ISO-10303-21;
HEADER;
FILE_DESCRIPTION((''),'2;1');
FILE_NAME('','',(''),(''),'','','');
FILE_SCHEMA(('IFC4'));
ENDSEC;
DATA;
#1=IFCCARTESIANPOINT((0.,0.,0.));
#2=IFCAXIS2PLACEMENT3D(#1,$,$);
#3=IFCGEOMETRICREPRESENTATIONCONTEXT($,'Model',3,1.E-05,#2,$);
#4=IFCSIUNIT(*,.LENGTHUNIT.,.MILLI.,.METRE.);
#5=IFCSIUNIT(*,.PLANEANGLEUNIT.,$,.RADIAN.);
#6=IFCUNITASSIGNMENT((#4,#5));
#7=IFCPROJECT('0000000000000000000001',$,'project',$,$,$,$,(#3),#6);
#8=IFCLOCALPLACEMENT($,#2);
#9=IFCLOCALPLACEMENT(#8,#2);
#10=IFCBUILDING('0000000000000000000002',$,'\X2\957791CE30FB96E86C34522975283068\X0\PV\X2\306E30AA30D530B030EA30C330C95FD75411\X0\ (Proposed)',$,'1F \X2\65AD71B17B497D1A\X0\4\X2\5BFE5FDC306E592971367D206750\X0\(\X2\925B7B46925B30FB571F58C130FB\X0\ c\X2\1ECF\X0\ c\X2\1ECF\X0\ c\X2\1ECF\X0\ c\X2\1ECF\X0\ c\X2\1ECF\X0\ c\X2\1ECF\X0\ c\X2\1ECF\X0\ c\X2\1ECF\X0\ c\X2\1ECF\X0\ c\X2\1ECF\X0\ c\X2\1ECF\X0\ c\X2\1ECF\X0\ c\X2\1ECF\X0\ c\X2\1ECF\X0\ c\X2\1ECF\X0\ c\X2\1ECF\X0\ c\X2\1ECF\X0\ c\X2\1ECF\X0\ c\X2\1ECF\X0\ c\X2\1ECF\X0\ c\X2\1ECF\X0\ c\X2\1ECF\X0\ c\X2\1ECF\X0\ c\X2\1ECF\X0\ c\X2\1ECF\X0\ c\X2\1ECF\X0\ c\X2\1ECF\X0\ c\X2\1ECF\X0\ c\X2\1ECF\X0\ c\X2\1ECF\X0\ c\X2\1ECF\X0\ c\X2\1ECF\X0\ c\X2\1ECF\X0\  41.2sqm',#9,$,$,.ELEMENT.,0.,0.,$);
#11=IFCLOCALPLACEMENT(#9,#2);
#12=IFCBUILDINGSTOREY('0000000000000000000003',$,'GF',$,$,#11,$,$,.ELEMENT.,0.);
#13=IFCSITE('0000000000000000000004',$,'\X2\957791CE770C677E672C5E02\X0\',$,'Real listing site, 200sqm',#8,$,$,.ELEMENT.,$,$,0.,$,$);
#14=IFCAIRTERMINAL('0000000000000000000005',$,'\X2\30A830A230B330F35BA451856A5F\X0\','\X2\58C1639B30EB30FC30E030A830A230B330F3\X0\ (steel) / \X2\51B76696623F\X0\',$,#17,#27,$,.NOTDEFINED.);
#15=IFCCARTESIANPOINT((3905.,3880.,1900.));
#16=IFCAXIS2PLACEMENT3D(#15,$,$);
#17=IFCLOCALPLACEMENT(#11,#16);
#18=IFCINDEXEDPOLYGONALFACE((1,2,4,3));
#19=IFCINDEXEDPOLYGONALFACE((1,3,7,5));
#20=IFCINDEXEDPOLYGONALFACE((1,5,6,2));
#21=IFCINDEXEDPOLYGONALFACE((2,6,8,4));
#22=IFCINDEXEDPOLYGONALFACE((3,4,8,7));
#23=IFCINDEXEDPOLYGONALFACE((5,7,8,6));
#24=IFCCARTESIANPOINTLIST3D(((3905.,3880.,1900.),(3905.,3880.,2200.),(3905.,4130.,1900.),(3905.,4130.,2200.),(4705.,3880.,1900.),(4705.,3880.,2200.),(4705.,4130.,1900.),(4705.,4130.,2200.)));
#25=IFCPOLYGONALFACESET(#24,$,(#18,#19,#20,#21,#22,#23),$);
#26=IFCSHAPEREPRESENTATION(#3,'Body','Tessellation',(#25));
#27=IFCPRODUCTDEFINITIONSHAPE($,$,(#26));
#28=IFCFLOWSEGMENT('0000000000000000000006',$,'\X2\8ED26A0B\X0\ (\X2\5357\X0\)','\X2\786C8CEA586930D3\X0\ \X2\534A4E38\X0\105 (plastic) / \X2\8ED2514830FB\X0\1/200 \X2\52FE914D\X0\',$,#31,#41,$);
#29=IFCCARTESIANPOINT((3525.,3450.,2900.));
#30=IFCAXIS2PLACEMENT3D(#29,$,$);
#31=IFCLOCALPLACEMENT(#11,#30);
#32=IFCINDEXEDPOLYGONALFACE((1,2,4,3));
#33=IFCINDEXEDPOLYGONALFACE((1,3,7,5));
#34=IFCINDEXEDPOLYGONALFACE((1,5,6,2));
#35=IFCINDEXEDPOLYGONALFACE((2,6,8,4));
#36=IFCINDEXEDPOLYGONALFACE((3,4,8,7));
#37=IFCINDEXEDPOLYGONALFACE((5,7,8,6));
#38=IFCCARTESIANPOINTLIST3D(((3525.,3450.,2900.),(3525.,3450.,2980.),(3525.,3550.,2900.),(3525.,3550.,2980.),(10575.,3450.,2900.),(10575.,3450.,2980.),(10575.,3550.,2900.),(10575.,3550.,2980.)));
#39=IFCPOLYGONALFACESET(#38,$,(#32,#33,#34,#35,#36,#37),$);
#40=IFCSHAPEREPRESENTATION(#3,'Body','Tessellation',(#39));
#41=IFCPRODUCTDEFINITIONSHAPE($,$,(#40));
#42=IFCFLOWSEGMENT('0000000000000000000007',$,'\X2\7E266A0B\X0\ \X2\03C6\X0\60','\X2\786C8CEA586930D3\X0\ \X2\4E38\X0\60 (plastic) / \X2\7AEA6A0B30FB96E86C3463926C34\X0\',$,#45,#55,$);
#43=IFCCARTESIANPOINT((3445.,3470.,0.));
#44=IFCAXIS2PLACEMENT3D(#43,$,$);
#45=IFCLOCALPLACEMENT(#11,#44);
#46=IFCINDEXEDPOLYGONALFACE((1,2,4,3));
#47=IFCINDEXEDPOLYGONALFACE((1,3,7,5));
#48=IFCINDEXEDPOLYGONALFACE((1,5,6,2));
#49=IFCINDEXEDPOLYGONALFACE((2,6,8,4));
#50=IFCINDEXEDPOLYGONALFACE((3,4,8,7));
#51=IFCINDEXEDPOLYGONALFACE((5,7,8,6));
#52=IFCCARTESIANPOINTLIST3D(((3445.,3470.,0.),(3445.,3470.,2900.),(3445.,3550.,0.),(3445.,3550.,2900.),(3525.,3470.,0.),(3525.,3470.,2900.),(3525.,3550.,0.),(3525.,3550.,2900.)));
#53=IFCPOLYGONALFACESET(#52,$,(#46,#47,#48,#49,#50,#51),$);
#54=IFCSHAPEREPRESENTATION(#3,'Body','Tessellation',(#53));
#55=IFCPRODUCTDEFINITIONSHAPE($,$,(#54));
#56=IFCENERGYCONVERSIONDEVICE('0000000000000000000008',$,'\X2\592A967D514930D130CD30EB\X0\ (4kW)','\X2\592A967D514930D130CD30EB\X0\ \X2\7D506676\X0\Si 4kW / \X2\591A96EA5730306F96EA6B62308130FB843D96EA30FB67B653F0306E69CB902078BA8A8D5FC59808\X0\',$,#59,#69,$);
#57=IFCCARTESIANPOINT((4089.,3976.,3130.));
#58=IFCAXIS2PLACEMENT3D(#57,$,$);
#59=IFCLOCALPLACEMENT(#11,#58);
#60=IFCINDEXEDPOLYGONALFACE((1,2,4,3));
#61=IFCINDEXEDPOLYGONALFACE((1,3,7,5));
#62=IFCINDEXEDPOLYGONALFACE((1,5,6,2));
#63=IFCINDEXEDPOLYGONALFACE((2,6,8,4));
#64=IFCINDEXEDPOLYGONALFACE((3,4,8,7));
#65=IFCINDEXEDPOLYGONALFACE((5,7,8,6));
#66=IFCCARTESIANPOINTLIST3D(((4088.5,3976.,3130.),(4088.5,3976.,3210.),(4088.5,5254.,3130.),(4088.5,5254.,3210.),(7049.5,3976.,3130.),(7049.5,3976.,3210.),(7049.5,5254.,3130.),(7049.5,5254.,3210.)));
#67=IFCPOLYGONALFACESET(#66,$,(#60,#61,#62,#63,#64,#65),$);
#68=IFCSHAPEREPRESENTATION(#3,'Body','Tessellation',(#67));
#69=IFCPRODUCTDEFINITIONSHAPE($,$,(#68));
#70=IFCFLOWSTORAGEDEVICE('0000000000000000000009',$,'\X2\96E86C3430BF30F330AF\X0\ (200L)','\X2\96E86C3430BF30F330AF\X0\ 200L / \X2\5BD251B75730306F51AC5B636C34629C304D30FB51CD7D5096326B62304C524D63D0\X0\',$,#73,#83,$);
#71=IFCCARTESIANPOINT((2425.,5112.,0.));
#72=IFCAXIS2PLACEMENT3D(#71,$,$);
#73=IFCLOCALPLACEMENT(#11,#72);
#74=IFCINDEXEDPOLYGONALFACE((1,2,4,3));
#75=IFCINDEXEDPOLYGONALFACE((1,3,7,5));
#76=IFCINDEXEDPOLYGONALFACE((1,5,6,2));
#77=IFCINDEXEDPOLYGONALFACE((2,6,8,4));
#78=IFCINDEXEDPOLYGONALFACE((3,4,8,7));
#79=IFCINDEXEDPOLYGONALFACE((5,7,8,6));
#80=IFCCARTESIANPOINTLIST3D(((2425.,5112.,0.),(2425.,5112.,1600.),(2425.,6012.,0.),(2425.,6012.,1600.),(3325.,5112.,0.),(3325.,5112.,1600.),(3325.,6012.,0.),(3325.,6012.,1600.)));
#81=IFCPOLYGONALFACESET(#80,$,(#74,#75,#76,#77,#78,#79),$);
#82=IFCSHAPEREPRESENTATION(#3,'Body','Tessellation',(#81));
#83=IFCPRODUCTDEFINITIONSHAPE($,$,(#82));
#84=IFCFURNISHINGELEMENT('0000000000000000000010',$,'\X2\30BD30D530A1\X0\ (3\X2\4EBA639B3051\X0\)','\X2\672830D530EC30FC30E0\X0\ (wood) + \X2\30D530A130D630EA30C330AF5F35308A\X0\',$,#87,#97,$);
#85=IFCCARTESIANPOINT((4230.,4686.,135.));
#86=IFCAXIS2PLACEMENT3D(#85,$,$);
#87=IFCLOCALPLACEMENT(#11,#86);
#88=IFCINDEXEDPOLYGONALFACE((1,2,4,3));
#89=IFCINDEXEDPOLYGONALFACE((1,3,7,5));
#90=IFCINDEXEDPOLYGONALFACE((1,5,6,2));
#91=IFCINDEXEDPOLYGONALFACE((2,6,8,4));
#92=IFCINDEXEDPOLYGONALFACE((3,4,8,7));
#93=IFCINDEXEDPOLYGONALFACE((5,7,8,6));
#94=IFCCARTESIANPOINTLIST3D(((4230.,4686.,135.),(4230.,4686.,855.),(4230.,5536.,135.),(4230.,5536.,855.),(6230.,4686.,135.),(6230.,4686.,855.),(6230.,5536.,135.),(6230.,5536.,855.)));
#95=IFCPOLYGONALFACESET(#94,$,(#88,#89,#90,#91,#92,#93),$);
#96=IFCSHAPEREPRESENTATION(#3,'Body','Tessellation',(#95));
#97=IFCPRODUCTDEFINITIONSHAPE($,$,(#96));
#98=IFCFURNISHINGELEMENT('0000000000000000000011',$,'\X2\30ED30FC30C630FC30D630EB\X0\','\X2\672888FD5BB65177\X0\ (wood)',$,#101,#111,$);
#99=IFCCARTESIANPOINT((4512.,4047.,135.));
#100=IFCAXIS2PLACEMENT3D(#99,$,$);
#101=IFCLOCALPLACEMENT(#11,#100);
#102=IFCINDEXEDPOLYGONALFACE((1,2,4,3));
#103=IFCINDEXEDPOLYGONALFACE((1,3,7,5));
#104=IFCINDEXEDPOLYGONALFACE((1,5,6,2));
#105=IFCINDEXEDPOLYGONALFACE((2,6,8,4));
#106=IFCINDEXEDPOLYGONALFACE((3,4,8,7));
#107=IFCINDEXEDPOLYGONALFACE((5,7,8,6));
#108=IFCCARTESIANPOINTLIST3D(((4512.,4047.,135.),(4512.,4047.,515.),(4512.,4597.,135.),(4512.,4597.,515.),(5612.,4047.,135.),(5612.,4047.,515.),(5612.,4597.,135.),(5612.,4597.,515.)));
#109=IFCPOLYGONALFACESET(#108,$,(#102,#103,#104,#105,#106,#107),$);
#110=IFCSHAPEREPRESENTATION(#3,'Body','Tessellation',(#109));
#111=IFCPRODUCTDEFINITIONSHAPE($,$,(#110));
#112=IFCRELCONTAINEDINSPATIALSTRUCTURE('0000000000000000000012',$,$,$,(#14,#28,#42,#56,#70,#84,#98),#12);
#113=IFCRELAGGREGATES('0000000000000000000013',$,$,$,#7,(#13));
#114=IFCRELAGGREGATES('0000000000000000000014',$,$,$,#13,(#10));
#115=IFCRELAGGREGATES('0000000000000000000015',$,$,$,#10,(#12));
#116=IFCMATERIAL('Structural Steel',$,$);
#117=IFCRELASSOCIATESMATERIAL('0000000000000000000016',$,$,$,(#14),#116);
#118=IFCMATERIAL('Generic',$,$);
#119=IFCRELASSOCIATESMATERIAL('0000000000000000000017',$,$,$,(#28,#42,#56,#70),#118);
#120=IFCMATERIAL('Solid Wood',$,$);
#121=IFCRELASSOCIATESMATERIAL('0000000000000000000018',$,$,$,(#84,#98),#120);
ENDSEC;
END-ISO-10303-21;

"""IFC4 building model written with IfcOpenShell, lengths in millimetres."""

from ifc_helpers import new_model, si_unit, frame, frame_2d, origin, place, context, project, spatial, rectangle, extrude, material, element, save


model = new_model("IFC4")

# Units and contexts
model_context = context("Model", 3, precision=1e-05, world=origin())
ifc_project = project(units=[si_unit("LENGTHUNIT", "METRE", prefix="MILLI"), si_unit("PLANEANGLEUNIT", "RADIAN")], contexts=[model_context])

# Site, building, storey
site_placement = place(None, origin())
site = spatial("IfcSite", under=ifc_project, at=site_placement, Name="長野県松本市", ObjectType="Real listing site, 200sqm", CompositionType="ELEMENT", RefElevation=0.0)
building_placement = place(site_placement, origin())
building = spatial("IfcBuilding", under=site, at=building_placement, Name="長野・雨水利用とPVのオフグリッド志向 (Proposed)", ObjectType="1F 断熱等級4対応の天然素材(鉛筆鉛・土壁・ cỏ cỏ cỏ cỏ cỏ cỏ cỏ cỏ cỏ cỏ cỏ cỏ cỏ cỏ cỏ cỏ cỏ cỏ cỏ cỏ cỏ cỏ cỏ cỏ cỏ cỏ cỏ cỏ cỏ cỏ cỏ cỏ cỏ  41.2sqm", CompositionType="ELEMENT", ElevationOfRefHeight=0.0, ElevationOfTerrain=0.0)
storey_placement = place(building_placement, origin())
storey = spatial("IfcBuildingStorey", under=building, at=storey_placement, Name="GF", CompositionType="ELEMENT", Elevation=0.0)

# Shared definitions
ifc_material_1 = material(Name="Solid Wood")

# Shared definitions
ifc_material_2 = material(Name="Structural Steel")

# Shared definitions
ifc_material_3 = material(Name="Generic")

# Air terminal
air_terminal_placement = place(storey_placement, frame((3905.0, 3880.0, 1900.0)))
element("IfcAirTerminal", 1, at=air_terminal_placement, inside=storey, material=ifc_material_2, Name="エアコン室内機", Description="壁掛ルームエアコン (steel) / 冷暖房", PredefinedType="NOTDEFINED", context=model_context, shape_type="SweptSolid", body=[
    extrude(rectangle(XDim=800.0, YDim=250.0, at=frame_2d((400.0, 125.0))), frame((3905.0, 3880.0, 1900.0)), (0.0, 0.0, 1.0), 300.0),
])

# Flow segments
flow_segment_1_placement = place(storey_placement, frame((3525.0, 3450.0, 2900.0)))
element("IfcFlowSegment", 2, at=flow_segment_1_placement, inside=storey, material=ifc_material_3, Name="軒樋 (南)", Description="硬質塩ビ 半丸105 (plastic) / 軒先・1/200 勾配", context=model_context, shape_type="SweptSolid", body=[
    extrude(rectangle(XDim=7050.0, YDim=100.0, at=frame_2d((3525.0, 50.0))), frame((3525.0, 3450.0, 2900.0)), (0.0, 0.0, 1.0), 80.0),
])
flow_segment_2_placement = place(storey_placement, frame((3445.0, 3470.0, 0.0)))
element("IfcFlowSegment", 3, at=flow_segment_2_placement, inside=storey, material=ifc_material_3, Name="縦樋 φ60", Description="硬質塩ビ 丸60 (plastic) / 竪樋・雨水排水", context=model_context, shape_type="SweptSolid", body=[
    extrude(rectangle(XDim=80.0, YDim=80.0, at=frame_2d((40.0, 40.0))), frame((3445.0, 3470.0, 0.0)), (0.0, 0.0, 1.0), 2900.0),
])

# Energy conversion device
energy_conversion_device_placement = place(storey_placement, frame((4089.0, 3976.0, 3130.0)))
element("IfcEnergyConversionDevice", 4, at=energy_conversion_device_placement, inside=storey, material=ifc_material_3, Name="太陽光パネル (4kW)", Description="太陽光パネル 結晶Si 4kW / 多雪地は雪止め・落雪・架台の構造確認必須", context=model_context, shape_type="SweptSolid", body=[
    extrude(rectangle(XDim=2961.0, YDim=1278.0, at=frame_2d((1480.0, 639.0))), frame((4089.0, 3976.0, 3130.0)), (0.0, 0.0, 1.0), 80.0),
])

# Flow storage device
flow_storage_device_placement = place(storey_placement, frame((2425.0, 5112.0, 0.0)))
element("IfcFlowStorageDevice", 5, at=flow_storage_device_placement, inside=storey, material=ifc_material_3, Name="雨水タンク (200L)", Description="雨水タンク 200L / 寒冷地は冬季水抜き・凍結防止が前提", context=model_context, shape_type="SweptSolid", body=[
    extrude(rectangle(XDim=900.0, YDim=900.0, at=frame_2d((450.0, 450.0))), frame((2425.0, 5112.0, 0.0)), (0.0, 0.0, 1.0), 1600.0),
])

# Furnishing elements
furnishing_1_placement = place(storey_placement, frame((4230.0, 4686.0, 135.0)))
element("IfcFurnishingElement", 6, at=furnishing_1_placement, inside=storey, material=ifc_material_1, Name="ソファ (3人掛け)", Description="木フレーム (wood) + ファブリック張り", context=model_context, shape_type="SweptSolid", body=[
    extrude(rectangle(XDim=2000.0, YDim=850.0, at=frame_2d((1000.0, 425.0))), frame((4230.0, 4686.0, 135.0)), (0.0, 0.0, 1.0), 720.0),
])
furnishing_2_placement = place(storey_placement, frame((4512.0, 4047.0, 135.0)))
element("IfcFurnishingElement", 7, at=furnishing_2_placement, inside=storey, material=ifc_material_1, Name="ローテーブル", Description="木製家具 (wood)", context=model_context, shape_type="SweptSolid", body=[
    extrude(rectangle(XDim=1100.0, YDim=550.0, at=frame_2d((550.0, 275.0))), frame((4512.0, 4047.0, 135.0)), (0.0, 0.0, 1.0), 380.0),
])

save(model, "model.ifc")
